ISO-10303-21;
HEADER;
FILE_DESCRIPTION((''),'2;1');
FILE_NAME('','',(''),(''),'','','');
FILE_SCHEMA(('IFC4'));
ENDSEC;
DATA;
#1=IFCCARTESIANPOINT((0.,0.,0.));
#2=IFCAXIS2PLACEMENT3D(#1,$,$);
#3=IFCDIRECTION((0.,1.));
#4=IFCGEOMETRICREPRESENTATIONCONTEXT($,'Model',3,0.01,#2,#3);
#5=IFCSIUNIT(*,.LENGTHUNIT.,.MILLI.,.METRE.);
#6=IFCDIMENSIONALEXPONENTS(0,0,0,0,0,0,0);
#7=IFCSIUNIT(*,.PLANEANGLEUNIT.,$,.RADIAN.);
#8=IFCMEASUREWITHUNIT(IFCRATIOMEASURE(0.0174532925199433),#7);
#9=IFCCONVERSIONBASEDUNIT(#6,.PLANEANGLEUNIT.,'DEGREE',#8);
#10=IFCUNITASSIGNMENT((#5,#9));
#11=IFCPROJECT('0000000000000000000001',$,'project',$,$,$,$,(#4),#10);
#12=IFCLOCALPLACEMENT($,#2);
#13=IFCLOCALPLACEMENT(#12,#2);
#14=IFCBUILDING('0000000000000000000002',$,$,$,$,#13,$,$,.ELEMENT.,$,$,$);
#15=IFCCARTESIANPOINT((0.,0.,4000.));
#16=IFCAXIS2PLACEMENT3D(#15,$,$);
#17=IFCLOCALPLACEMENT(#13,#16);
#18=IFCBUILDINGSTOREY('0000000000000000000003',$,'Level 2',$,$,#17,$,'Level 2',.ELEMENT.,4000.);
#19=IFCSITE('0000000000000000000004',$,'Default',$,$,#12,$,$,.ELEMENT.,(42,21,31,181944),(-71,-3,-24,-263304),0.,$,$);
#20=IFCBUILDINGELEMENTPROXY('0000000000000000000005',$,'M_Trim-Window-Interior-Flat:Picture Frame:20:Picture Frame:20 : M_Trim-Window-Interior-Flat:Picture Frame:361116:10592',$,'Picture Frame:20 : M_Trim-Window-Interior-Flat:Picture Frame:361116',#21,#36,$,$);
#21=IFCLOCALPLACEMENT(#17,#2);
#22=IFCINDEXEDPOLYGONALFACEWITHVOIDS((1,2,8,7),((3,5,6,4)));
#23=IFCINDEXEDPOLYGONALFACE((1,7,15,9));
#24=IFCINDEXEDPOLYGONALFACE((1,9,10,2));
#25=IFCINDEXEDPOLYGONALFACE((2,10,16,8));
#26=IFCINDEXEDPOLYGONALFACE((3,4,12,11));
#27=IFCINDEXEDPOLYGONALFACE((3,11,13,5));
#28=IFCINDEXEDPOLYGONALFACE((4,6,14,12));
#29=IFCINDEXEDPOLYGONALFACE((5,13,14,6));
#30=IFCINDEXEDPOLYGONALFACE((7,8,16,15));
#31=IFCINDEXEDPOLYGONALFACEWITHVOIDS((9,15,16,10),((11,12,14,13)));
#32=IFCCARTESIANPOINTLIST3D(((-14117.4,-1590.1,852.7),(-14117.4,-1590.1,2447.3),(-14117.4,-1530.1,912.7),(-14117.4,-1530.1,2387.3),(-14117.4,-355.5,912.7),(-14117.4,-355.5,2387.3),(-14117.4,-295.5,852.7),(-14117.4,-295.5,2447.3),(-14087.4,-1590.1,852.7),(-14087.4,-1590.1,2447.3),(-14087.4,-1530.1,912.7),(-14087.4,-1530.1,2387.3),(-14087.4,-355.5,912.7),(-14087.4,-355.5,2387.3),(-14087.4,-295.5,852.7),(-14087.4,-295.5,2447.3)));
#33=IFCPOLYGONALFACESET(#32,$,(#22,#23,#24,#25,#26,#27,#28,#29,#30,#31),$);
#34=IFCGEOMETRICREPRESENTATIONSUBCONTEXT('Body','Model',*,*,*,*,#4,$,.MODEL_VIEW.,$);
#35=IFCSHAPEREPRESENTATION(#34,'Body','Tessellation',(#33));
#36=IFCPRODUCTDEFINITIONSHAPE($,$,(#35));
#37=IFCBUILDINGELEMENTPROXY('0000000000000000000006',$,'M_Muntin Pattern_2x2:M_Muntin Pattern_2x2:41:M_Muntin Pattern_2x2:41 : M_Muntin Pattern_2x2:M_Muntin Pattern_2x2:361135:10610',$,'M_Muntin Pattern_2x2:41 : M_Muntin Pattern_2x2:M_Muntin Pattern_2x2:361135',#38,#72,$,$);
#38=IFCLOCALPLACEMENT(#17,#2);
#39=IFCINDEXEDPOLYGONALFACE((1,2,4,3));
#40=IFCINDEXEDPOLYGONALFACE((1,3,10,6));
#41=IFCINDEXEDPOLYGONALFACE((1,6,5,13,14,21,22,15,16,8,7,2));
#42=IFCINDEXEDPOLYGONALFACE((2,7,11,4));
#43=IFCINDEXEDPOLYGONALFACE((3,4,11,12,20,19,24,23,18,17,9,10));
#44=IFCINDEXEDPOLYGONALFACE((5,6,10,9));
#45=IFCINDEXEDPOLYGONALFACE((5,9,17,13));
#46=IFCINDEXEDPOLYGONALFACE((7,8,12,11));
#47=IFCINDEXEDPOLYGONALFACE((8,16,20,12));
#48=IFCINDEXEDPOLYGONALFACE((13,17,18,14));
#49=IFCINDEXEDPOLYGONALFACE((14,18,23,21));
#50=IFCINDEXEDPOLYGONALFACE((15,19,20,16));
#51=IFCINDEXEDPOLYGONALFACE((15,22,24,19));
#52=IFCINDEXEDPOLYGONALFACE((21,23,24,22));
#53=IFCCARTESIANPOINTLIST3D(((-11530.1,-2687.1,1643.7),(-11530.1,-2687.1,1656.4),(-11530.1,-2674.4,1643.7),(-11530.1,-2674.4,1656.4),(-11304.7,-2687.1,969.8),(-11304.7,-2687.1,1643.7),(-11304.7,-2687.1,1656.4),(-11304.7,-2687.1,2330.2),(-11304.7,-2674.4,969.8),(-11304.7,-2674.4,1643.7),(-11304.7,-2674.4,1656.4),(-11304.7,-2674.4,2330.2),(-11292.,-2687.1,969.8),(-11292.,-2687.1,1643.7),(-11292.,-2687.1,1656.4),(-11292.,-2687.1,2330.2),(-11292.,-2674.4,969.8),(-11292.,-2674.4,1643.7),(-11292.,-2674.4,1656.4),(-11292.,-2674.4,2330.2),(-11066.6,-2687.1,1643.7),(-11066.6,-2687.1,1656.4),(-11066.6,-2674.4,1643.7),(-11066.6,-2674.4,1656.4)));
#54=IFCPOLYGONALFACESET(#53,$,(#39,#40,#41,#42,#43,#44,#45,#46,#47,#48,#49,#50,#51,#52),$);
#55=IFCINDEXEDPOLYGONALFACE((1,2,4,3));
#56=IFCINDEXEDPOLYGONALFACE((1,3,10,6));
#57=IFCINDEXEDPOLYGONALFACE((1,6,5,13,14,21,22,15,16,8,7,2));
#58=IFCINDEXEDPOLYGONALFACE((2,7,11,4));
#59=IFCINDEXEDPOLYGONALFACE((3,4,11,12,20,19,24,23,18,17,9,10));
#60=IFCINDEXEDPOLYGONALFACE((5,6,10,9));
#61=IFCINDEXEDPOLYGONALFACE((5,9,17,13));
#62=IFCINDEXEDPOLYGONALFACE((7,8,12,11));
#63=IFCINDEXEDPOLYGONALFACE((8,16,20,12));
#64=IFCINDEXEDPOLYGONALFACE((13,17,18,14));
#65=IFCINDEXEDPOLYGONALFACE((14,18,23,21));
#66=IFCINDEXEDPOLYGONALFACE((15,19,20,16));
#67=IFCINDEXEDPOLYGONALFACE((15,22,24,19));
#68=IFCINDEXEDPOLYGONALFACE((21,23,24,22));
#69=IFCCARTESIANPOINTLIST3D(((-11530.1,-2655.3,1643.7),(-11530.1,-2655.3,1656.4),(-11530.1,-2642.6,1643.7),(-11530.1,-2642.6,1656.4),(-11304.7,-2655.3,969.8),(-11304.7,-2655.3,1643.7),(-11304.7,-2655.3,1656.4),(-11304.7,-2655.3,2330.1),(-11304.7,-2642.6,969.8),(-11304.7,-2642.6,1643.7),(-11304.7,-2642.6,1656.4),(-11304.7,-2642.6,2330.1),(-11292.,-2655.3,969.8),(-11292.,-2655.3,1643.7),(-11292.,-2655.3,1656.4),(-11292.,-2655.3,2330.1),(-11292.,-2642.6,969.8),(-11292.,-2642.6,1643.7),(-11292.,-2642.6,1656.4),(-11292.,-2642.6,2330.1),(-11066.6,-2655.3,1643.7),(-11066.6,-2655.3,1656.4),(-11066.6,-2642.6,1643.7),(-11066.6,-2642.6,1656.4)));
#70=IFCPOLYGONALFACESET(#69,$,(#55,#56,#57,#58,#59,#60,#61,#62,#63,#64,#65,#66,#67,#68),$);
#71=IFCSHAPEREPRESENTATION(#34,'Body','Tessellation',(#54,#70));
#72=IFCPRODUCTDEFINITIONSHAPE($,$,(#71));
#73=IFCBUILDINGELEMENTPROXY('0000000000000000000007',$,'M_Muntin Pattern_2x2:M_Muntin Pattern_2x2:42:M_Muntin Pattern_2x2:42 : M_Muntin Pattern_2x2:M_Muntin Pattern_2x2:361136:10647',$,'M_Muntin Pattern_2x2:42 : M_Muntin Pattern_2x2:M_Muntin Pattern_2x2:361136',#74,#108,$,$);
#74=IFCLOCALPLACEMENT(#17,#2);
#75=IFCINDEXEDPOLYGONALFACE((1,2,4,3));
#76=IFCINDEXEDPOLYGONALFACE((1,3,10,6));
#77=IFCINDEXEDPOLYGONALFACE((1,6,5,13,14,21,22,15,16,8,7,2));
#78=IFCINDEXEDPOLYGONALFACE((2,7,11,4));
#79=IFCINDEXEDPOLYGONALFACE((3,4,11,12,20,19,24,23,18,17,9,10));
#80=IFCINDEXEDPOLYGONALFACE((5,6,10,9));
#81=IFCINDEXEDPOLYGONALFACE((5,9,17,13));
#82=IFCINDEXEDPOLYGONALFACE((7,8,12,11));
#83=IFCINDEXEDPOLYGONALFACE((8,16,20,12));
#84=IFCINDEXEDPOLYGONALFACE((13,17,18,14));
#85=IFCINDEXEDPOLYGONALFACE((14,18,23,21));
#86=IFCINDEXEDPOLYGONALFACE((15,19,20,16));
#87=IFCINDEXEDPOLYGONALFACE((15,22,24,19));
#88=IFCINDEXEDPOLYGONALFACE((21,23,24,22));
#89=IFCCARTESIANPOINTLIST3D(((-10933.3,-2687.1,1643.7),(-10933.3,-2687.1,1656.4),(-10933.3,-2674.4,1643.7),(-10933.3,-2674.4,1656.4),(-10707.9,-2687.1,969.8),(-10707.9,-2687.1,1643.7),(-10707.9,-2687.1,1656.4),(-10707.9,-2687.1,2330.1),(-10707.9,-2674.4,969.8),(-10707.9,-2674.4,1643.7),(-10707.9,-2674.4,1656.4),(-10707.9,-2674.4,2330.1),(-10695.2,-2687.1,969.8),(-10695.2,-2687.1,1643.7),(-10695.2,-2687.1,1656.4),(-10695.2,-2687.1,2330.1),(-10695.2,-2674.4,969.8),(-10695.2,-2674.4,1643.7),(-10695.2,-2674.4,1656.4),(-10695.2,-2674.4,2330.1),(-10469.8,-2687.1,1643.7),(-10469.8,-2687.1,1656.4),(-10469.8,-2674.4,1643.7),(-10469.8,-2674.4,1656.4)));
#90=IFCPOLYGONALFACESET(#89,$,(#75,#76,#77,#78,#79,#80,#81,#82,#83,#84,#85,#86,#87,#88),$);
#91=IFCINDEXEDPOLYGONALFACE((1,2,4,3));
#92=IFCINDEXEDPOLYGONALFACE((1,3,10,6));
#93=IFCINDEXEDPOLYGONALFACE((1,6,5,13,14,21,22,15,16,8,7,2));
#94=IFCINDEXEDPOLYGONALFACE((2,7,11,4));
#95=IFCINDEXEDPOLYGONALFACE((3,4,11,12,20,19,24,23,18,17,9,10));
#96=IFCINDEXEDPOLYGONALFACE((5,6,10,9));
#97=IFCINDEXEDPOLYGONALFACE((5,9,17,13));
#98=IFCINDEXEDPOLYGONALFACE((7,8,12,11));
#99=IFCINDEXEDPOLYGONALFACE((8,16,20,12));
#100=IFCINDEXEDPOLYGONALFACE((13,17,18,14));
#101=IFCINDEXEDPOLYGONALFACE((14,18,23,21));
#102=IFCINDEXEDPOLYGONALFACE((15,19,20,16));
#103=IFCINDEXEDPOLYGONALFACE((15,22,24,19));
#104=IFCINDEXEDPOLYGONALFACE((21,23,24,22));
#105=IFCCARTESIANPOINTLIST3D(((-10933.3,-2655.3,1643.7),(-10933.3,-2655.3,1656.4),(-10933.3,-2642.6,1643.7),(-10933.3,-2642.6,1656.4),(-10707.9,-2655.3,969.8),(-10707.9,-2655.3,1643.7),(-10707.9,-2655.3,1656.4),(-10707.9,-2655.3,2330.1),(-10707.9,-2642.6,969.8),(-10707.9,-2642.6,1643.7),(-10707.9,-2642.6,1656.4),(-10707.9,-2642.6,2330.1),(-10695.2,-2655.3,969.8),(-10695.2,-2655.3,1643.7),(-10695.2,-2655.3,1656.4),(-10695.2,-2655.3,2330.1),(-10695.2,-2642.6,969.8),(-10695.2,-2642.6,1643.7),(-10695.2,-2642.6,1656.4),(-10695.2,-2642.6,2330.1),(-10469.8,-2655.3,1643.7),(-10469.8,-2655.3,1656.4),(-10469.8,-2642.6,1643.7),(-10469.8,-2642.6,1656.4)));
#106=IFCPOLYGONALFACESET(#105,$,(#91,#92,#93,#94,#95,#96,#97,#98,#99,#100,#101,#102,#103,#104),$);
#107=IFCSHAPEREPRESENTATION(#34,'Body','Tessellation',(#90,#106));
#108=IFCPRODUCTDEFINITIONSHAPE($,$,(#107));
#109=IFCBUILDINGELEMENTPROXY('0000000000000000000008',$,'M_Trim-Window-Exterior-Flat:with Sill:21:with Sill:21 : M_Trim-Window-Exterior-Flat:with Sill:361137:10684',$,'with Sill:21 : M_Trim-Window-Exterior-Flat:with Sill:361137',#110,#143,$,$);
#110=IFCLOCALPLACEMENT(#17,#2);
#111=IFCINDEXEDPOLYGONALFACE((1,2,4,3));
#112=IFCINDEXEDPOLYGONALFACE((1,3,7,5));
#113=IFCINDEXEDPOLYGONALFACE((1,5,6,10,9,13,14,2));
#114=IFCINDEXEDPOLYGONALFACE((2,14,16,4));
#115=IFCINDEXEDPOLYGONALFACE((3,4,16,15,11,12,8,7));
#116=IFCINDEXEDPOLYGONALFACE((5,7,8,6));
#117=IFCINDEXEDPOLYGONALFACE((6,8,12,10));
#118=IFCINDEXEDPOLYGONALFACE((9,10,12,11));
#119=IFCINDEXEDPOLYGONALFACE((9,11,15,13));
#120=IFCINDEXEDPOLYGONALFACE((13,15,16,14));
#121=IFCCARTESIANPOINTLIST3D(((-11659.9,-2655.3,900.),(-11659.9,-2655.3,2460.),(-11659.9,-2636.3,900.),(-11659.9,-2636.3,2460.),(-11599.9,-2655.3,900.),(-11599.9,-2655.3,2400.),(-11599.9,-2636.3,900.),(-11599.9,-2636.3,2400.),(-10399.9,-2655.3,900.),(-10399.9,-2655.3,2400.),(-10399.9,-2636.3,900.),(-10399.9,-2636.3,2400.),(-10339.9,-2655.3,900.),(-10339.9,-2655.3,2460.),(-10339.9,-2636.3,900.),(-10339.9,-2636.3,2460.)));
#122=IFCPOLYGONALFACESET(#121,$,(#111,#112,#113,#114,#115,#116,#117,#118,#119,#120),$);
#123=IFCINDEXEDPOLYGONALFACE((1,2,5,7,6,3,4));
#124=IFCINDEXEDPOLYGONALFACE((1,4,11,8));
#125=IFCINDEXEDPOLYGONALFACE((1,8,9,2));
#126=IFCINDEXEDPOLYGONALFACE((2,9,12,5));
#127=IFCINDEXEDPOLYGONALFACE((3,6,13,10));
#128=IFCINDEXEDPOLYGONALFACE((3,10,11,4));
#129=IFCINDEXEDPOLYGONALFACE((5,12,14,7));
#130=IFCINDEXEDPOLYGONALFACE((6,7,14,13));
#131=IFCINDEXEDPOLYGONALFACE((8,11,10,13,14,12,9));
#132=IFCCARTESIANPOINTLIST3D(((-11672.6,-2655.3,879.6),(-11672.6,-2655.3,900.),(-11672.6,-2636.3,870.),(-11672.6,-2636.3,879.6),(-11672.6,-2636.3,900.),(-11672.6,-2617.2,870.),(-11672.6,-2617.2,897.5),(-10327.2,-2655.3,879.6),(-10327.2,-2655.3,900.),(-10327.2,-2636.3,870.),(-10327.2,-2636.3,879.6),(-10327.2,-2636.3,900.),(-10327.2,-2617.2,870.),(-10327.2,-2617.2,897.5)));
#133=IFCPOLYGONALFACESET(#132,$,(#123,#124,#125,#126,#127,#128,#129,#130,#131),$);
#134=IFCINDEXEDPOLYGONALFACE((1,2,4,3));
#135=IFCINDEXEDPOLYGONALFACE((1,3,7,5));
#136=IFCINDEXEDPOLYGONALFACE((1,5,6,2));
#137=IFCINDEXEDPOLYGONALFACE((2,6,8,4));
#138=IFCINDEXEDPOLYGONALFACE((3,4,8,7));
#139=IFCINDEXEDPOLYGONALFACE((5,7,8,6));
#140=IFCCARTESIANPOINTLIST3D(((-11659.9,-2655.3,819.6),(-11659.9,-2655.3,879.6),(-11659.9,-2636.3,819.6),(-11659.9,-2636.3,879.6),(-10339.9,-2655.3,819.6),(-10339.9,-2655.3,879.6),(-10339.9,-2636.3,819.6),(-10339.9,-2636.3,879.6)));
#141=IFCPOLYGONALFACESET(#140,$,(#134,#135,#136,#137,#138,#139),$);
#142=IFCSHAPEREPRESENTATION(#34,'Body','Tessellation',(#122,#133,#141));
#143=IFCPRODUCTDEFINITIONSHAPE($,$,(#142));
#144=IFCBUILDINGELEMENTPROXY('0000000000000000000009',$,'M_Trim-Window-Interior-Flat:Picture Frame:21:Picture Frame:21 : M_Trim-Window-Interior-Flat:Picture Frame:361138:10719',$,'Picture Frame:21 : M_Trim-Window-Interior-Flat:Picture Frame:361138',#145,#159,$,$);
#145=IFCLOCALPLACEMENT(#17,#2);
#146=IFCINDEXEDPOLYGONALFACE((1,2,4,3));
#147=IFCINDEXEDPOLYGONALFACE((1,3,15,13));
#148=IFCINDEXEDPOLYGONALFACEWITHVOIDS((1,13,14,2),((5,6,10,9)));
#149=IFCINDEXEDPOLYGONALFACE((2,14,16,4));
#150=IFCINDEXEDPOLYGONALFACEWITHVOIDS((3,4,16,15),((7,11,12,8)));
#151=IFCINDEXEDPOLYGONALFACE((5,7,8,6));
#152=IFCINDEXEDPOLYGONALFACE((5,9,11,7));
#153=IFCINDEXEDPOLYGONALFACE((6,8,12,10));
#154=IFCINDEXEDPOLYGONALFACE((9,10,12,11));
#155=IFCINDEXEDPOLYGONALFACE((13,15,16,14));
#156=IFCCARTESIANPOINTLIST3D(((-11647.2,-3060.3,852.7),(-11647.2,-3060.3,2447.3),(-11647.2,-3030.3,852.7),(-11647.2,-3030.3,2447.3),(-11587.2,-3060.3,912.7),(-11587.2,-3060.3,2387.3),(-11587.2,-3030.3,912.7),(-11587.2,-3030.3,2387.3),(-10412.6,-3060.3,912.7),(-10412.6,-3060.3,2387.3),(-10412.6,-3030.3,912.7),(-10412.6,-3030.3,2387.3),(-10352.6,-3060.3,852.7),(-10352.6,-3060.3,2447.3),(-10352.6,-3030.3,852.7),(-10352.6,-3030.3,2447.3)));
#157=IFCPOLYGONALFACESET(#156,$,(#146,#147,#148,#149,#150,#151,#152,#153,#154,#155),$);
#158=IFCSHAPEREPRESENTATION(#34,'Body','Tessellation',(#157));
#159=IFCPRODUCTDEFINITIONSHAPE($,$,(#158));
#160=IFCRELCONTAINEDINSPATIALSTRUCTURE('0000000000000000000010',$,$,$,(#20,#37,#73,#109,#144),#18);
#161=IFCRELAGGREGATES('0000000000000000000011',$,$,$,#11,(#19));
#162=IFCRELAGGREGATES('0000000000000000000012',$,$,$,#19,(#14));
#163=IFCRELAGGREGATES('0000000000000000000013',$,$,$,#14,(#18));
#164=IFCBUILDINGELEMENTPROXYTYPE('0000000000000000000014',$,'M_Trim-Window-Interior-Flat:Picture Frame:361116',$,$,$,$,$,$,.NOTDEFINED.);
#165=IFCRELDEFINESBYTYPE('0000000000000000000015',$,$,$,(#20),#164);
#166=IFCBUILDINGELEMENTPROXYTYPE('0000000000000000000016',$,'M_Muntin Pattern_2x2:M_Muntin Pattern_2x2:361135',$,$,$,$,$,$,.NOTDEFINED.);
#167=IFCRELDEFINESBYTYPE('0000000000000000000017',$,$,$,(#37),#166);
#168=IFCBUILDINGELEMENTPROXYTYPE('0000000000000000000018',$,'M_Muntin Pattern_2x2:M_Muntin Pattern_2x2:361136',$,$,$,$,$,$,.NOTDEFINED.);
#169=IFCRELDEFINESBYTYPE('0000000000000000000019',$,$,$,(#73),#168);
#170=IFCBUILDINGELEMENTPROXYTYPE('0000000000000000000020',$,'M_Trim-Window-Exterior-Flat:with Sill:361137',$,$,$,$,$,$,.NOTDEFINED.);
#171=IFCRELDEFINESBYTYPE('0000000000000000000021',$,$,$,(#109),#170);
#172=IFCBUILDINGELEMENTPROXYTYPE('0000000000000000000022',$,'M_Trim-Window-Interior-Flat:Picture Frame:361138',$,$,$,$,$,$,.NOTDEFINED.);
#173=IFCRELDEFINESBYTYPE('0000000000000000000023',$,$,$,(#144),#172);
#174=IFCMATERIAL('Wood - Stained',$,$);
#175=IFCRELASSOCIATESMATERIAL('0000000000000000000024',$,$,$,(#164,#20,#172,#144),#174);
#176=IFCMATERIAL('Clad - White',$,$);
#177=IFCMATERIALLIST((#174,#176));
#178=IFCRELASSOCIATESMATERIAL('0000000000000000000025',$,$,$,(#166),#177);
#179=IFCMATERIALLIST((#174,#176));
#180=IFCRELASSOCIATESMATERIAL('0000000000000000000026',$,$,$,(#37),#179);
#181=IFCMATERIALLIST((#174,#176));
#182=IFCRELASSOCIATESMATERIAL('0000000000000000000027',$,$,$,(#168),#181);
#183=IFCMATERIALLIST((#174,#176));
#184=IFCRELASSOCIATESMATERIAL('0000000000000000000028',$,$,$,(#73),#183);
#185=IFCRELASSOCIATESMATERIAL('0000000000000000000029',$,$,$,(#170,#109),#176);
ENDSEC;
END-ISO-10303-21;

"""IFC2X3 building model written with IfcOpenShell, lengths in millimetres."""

from ifc_helpers import new_model, entity, si_unit, converted_unit, direction, frame, origin, origin_2d_with_axis, place, context, subcontext, project, spatial, polyline, rectangle, outline, extrude, source, transform, mapped, material, material_list, type_object, type_shapes, element, save


model = new_model("IFC2X3")

# Units and contexts
model_context = context("Model", 3, precision=0.01, world=origin(), true_north=direction((0.0, 1.0)))
body_context = subcontext(model_context, "Body", "Model", "MODEL_VIEW")
ifc_project = project(units=[si_unit("LENGTHUNIT", "METRE", prefix="MILLI"), converted_unit("PLANEANGLEUNIT", "DEGREE", entity("IfcRatioMeasure", 0.0174532925199433), si_unit("PLANEANGLEUNIT", "RADIAN"), dimensions=[0, 0, 0, 0, 0, 0, 0])], contexts=[model_context])

# Site, building, storey
site_placement = place(None, origin())
site = spatial("IfcSite", under=ifc_project, at=site_placement, Name="Default", CompositionType="ELEMENT", RefLatitude=(42, 21, 31, 181944), RefLongitude=(-71, -3, -24, -263304), RefElevation=0.0)
building_placement = place(site_placement, origin())
building = spatial("IfcBuilding", under=site, at=building_placement, CompositionType="ELEMENT")
storey_placement = place(building_placement, frame((0.0, 0.0, 4000.0)))
storey = spatial("IfcBuildingStorey", under=building, at=storey_placement, Name="Level 2", LongName="Level 2", CompositionType="ELEMENT", Elevation=4000.0)

# Building element proxies
ifc_material_1 = material(Name="Wood - Stained")
ifc_material_2 = material(Name="Clad - White")
building_element_proxy_type_1 = type_object("IfcBuildingElementProxyType", Name="M_Trim-Window-Interior-Flat:Picture Frame:361116", PredefinedType="NOTDEFINED", material=ifc_material_1)
shared_shape_1 = source(origin(), body_context, "Body", "SweptSolid", [
    extrude(outline(polyline([(-647.3, -797.3), (647.3, -797.3), (647.3, 797.3), (-647.3, 797.3), (-647.3, -797.3)]), holes=[polyline([(587.3, 737.3), (587.3, -737.3), (-587.3, -737.3), (-587.3, 737.3), (587.3, 737.3)])]), frame((-14117.4, -942.8, 5650.0), z_axis=(1.0, 0.0, 0.0), x_axis=(0.0, -1.0, 0.0)), (0.0, 0.0, 1.0), 30.0),
])
type_shapes(building_element_proxy_type_1, [shared_shape_1])
proxy_1_placement = place(storey_placement, frame((0.0, 0.0, -4000.0)))
element("IfcBuildingElementProxy", 1, at=proxy_1_placement, inside=storey, type_object=building_element_proxy_type_1, material=ifc_material_1, Name="M_Trim-Window-Interior-Flat:Picture Frame:20:Picture Frame:20 : M_Trim-Window-Interior-Flat:Picture Frame:361116:10592", ObjectType="Picture Frame:20 : M_Trim-Window-Interior-Flat:Picture Frame:361116", context=body_context, shape_type="MappedRepresentation", body=[
    mapped(shared_shape_1, transform((0.0, 0.0, 0.0), scale=1.0)),
])
ifc_material_list_1 = material_list([ifc_material_1, ifc_material_2])
ifc_material_list_2 = material_list([ifc_material_1, ifc_material_2])
building_element_proxy_type_2 = type_object("IfcBuildingElementProxyType", Name="M_Muntin Pattern_2x2:M_Muntin Pattern_2x2:361135", PredefinedType="NOTDEFINED", material=ifc_material_list_2)
shared_shape_2 = source(origin(), body_context, "Body", "SweptSolid", [
    extrude(outline(polyline([(-6.4, -680.2), (6.3, -680.2), (6.3, -6.4), (231.7, -6.4), (231.7, 6.3), (6.3, 6.3), (6.3, 680.2), (-6.4, 680.2), (-6.4, 6.3), (-231.7, 6.3), (-231.7, -6.4), (-6.4, -6.4), (-6.4, -680.2)])), frame((-11298.4, -2687.1, 5650.0), z_axis=(0.0, 1.0, 0.0), x_axis=(1.0, 0.0, 0.0)), (0.0, 0.0, 1.0), 12.7),
    extrude(outline(polyline([(-6.4, -680.1), (6.3, -680.1), (6.3, -6.4), (231.7, -6.4), (231.7, 6.3), (6.3, 6.3), (6.3, 680.2), (-6.4, 680.2), (-6.4, 6.3), (-231.7, 6.3), (-231.7, -6.4), (-6.4, -6.4), (-6.4, -680.1)])), frame((-11298.4, -2655.3, 5650.0), z_axis=(0.0, 1.0, 0.0), x_axis=(1.0, 0.0, 0.0)), (0.0, 0.0, 1.0), 12.7),
])
type_shapes(building_element_proxy_type_2, [shared_shape_2])
proxy_2_placement = place(storey_placement, frame((0.0, 0.0, -4000.0)))
element("IfcBuildingElementProxy", 2, at=proxy_2_placement, inside=storey, type_object=building_element_proxy_type_2, material=ifc_material_list_1, Name="M_Muntin Pattern_2x2:M_Muntin Pattern_2x2:41:M_Muntin Pattern_2x2:41 : M_Muntin Pattern_2x2:M_Muntin Pattern_2x2:361135:10610", ObjectType="M_Muntin Pattern_2x2:41 : M_Muntin Pattern_2x2:M_Muntin Pattern_2x2:361135", context=body_context, shape_type="MappedRepresentation", body=[
    mapped(shared_shape_2, transform((0.0, 0.0, 0.0), scale=1.0)),
])
ifc_material_list_3 = material_list([ifc_material_1, ifc_material_2])
ifc_material_list_4 = material_list([ifc_material_1, ifc_material_2])
building_element_proxy_type_3 = type_object("IfcBuildingElementProxyType", Name="M_Muntin Pattern_2x2:M_Muntin Pattern_2x2:361136", PredefinedType="NOTDEFINED", material=ifc_material_list_4)
shared_shape_3 = source(origin(), body_context, "Body", "SweptSolid", [
    extrude(outline(polyline([(-680.1, 6.4), (-680.1, -6.3), (-6.4, -6.3), (-6.4, -231.7), (6.3, -231.7), (6.3, -6.3), (680.2, -6.3), (680.2, 6.4), (6.3, 6.4), (6.3, 231.7), (-6.4, 231.7), (-6.4, 6.4), (-680.1, 6.4)])), frame((-10701.5, -2687.1, 5650.0), z_axis=(0.0, -1.0, 0.0), x_axis=(0.0, 0.0, -1.0)), (0.0, 0.0, -1.0), 12.7),
    extrude(outline(polyline([(-680.1, 6.4), (-680.1, -6.3), (-6.4, -6.3), (-6.4, -231.7), (6.3, -231.7), (6.3, -6.3), (680.2, -6.3), (680.2, 6.4), (6.3, 6.4), (6.3, 231.7), (-6.4, 231.7), (-6.4, 6.4), (-680.1, 6.4)])), frame((-10701.5, -2655.3, 5650.0), z_axis=(0.0, -1.0, 0.0), x_axis=(0.0, 0.0, -1.0)), (0.0, 0.0, -1.0), 12.7),
])
type_shapes(building_element_proxy_type_3, [shared_shape_3])
proxy_3_placement = place(storey_placement, frame((0.0, 0.0, -4000.0)))
element("IfcBuildingElementProxy", 3, at=proxy_3_placement, inside=storey, type_object=building_element_proxy_type_3, material=ifc_material_list_3, Name="M_Muntin Pattern_2x2:M_Muntin Pattern_2x2:42:M_Muntin Pattern_2x2:42 : M_Muntin Pattern_2x2:M_Muntin Pattern_2x2:361136:10647", ObjectType="M_Muntin Pattern_2x2:42 : M_Muntin Pattern_2x2:M_Muntin Pattern_2x2:361136", context=body_context, shape_type="MappedRepresentation", body=[
    mapped(shared_shape_3, transform((0.0, 0.0, 0.0), scale=1.0)),
])
building_element_proxy_type_4 = type_object("IfcBuildingElementProxyType", Name="M_Trim-Window-Exterior-Flat:with Sill:361137", PredefinedType="NOTDEFINED", material=ifc_material_2)
shared_shape_4 = source(origin(), body_context, "Body", "SweptSolid", [
    extrude(outline(polyline([(-660.0, -765.0), (-600.0, -765.0), (-600.0, 735.0), (600.0, 735.0), (600.0, -765.0), (660.0, -765.0), (660.0, 795.0), (-660.0, 795.0), (-660.0, -765.0)])), frame((-10999.9, -2655.3, 5665.0), z_axis=(0.0, 1.0, 0.0), x_axis=(-1.0, 0.0, 0.0)), (0.0, 0.0, 1.0), 19.1),
    extrude(outline(polyline([(0.0, -15.2), (19.0, -15.2), (19.0, 12.3), (0.0, 14.8), (-19.0, 14.8), (-19.0, -5.7), (0.0, -5.7), (0.0, -15.2)])), frame((-11672.6, -2636.3, 4885.2), z_axis=(1.0, 0.0, 0.0), x_axis=(0.0, 1.0, 0.0)), (0.0, 0.0, 1.0), 1345.4),
    extrude(rectangle(XDim=19.1, YDim=1320.0, at=origin_2d_with_axis()), frame((-10999.9, -2645.8, 4819.6), z_axis=(0.0, 0.0, 1.0), x_axis=(0.0, -1.0, 0.0)), (0.0, 0.0, 1.0), 60.0),
])
type_shapes(building_element_proxy_type_4, [shared_shape_4])
proxy_4_placement = place(storey_placement, frame((0.0, 0.0, -4000.0)))
element("IfcBuildingElementProxy", 4, at=proxy_4_placement, inside=storey, type_object=building_element_proxy_type_4, material=ifc_material_2, Name="M_Trim-Window-Exterior-Flat:with Sill:21:with Sill:21 : M_Trim-Window-Exterior-Flat:with Sill:361137:10684", ObjectType="with Sill:21 : M_Trim-Window-Exterior-Flat:with Sill:361137", context=body_context, shape_type="MappedRepresentation", body=[
    mapped(shared_shape_4, transform((0.0, 0.0, 0.0), scale=1.0)),
])
building_element_proxy_type_5 = type_object("IfcBuildingElementProxyType", Name="M_Trim-Window-Interior-Flat:Picture Frame:361138", PredefinedType="NOTDEFINED", material=ifc_material_1)
shared_shape_5 = source(origin(), body_context, "Body", "SweptSolid", [
    extrude(outline(polyline([(-647.3, -797.3), (647.3, -797.3), (647.3, 797.3), (-647.3, 797.3), (-647.3, -797.3)]), holes=[polyline([(587.3, 737.3), (587.3, -737.3), (-587.3, -737.3), (-587.3, 737.3), (587.3, 737.3)])]), frame((-10999.9, -3060.3, 5650.0), z_axis=(0.0, 1.0, 0.0), x_axis=(1.0, 0.0, 0.0)), (0.0, 0.0, 1.0), 30.0),
])
type_shapes(building_element_proxy_type_5, [shared_shape_5])
proxy_5_placement = place(storey_placement, frame((0.0, 0.0, -4000.0)))
element("IfcBuildingElementProxy", 5, at=proxy_5_placement, inside=storey, type_object=building_element_proxy_type_5, material=ifc_material_1, Name="M_Trim-Window-Interior-Flat:Picture Frame:21:Picture Frame:21 : M_Trim-Window-Interior-Flat:Picture Frame:361138:10719", ObjectType="Picture Frame:21 : M_Trim-Window-Interior-Flat:Picture Frame:361138", context=body_context, shape_type="MappedRepresentation", body=[
    mapped(shared_shape_5, transform((0.0, 0.0, 0.0), scale=1.0)),
])

save(model, "model.ifc")
